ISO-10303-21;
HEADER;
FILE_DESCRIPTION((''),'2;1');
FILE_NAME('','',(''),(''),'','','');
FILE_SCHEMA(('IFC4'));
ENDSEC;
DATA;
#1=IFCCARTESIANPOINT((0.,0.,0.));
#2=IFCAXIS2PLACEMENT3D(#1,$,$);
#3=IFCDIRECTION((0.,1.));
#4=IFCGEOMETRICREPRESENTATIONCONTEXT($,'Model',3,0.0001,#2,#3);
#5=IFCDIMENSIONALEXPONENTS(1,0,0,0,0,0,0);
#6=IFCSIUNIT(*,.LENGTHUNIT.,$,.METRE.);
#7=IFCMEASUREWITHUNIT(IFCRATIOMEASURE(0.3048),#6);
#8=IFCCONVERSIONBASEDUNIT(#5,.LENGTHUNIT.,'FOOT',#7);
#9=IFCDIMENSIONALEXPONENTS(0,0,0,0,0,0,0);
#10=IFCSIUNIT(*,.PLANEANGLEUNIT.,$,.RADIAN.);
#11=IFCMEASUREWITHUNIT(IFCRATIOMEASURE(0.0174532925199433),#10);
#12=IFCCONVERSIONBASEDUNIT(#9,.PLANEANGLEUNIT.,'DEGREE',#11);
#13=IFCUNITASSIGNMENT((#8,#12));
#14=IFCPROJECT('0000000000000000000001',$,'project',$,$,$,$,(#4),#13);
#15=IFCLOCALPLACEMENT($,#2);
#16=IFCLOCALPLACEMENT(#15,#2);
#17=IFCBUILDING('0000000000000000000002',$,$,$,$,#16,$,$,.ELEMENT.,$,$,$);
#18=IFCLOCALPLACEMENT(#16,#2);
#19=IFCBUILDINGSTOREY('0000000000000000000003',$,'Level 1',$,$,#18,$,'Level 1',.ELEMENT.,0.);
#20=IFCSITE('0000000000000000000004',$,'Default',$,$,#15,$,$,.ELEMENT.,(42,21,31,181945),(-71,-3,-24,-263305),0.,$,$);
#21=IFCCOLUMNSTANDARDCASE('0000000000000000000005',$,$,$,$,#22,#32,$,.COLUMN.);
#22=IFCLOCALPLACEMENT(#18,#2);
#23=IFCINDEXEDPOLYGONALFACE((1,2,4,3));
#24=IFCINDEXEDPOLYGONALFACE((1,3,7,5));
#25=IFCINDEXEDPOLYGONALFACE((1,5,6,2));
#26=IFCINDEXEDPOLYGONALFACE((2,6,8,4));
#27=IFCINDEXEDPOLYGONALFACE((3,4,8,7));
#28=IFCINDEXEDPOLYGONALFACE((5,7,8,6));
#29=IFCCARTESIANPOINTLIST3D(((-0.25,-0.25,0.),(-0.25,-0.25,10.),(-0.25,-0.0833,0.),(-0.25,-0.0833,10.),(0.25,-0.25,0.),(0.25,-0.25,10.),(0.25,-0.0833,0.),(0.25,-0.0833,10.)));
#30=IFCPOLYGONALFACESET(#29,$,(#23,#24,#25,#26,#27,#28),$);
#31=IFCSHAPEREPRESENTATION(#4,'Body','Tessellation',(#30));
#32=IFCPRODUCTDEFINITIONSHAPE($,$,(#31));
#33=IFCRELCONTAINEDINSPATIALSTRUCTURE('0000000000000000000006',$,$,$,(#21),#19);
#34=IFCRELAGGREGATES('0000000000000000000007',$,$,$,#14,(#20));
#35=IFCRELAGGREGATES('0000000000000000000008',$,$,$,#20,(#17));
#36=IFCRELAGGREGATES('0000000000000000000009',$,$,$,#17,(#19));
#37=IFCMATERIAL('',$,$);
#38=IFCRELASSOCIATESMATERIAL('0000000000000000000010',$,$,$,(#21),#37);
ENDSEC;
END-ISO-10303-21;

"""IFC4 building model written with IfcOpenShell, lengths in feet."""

from ifc_helpers import new_model, entity, si_unit, converted_unit, direction, frame, origin, place, context, project, spatial, rectangle, extrude, material, element, save


model = new_model("IFC4")

# Units and contexts
model_context = context("Model", 3, precision=0.0001, world=origin(), true_north=direction((0.0, 1.0)))
ifc_project = project(units=[converted_unit("LENGTHUNIT", "FOOT", entity("IfcRatioMeasure", 0.3048), si_unit("LENGTHUNIT", "METRE"), dimensions=[1, 0, 0, 0, 0, 0, 0]), converted_unit("PLANEANGLEUNIT", "DEGREE", entity("IfcRatioMeasure", 0.0174532925199433), si_unit("PLANEANGLEUNIT", "RADIAN"), dimensions=[0, 0, 0, 0, 0, 0, 0])], contexts=[model_context])

# Site, building, storey
site_placement = place(None, origin())
site = spatial("IfcSite", under=ifc_project, at=site_placement, Name="Default", CompositionType="ELEMENT", RefLatitude=(42, 21, 31, 181945), RefLongitude=(-71, -3, -24, -263305), RefElevation=0.0)
building_placement = place(site_placement, origin())
building = spatial("IfcBuilding", under=site, at=building_placement, CompositionType="ELEMENT")
storey_placement = place(building_placement, origin())
storey = spatial("IfcBuildingStorey", under=building, at=storey_placement, Name="Level 1", LongName="Level 1", CompositionType="ELEMENT", Elevation=0.0)

# Column
ifc_material_1 = material(Name="")
wall_placement = place(storey_placement, frame((0.0, -0.25, 0.0), z_axis=(0.0, 0.0, 1.0), x_axis=(0.0, 1.0, 0.0)))
column_placement = place(wall_placement, frame((0.0833, 0.0, 0.0), z_axis=(0.0, 0.0, 1.0), x_axis=(1.0, 0.0, 0.0)))
element("IfcColumnStandardCase", 1, at=column_placement, inside=storey, material=ifc_material_1, PredefinedType="COLUMN", context=model_context, shape_type="SweptSolid", body=[
    extrude(rectangle(XDim=0.1667, YDim=0.5), origin(), (0.0, 0.0, 1.0), 10.0),
])

save(model, "model.ifc")
